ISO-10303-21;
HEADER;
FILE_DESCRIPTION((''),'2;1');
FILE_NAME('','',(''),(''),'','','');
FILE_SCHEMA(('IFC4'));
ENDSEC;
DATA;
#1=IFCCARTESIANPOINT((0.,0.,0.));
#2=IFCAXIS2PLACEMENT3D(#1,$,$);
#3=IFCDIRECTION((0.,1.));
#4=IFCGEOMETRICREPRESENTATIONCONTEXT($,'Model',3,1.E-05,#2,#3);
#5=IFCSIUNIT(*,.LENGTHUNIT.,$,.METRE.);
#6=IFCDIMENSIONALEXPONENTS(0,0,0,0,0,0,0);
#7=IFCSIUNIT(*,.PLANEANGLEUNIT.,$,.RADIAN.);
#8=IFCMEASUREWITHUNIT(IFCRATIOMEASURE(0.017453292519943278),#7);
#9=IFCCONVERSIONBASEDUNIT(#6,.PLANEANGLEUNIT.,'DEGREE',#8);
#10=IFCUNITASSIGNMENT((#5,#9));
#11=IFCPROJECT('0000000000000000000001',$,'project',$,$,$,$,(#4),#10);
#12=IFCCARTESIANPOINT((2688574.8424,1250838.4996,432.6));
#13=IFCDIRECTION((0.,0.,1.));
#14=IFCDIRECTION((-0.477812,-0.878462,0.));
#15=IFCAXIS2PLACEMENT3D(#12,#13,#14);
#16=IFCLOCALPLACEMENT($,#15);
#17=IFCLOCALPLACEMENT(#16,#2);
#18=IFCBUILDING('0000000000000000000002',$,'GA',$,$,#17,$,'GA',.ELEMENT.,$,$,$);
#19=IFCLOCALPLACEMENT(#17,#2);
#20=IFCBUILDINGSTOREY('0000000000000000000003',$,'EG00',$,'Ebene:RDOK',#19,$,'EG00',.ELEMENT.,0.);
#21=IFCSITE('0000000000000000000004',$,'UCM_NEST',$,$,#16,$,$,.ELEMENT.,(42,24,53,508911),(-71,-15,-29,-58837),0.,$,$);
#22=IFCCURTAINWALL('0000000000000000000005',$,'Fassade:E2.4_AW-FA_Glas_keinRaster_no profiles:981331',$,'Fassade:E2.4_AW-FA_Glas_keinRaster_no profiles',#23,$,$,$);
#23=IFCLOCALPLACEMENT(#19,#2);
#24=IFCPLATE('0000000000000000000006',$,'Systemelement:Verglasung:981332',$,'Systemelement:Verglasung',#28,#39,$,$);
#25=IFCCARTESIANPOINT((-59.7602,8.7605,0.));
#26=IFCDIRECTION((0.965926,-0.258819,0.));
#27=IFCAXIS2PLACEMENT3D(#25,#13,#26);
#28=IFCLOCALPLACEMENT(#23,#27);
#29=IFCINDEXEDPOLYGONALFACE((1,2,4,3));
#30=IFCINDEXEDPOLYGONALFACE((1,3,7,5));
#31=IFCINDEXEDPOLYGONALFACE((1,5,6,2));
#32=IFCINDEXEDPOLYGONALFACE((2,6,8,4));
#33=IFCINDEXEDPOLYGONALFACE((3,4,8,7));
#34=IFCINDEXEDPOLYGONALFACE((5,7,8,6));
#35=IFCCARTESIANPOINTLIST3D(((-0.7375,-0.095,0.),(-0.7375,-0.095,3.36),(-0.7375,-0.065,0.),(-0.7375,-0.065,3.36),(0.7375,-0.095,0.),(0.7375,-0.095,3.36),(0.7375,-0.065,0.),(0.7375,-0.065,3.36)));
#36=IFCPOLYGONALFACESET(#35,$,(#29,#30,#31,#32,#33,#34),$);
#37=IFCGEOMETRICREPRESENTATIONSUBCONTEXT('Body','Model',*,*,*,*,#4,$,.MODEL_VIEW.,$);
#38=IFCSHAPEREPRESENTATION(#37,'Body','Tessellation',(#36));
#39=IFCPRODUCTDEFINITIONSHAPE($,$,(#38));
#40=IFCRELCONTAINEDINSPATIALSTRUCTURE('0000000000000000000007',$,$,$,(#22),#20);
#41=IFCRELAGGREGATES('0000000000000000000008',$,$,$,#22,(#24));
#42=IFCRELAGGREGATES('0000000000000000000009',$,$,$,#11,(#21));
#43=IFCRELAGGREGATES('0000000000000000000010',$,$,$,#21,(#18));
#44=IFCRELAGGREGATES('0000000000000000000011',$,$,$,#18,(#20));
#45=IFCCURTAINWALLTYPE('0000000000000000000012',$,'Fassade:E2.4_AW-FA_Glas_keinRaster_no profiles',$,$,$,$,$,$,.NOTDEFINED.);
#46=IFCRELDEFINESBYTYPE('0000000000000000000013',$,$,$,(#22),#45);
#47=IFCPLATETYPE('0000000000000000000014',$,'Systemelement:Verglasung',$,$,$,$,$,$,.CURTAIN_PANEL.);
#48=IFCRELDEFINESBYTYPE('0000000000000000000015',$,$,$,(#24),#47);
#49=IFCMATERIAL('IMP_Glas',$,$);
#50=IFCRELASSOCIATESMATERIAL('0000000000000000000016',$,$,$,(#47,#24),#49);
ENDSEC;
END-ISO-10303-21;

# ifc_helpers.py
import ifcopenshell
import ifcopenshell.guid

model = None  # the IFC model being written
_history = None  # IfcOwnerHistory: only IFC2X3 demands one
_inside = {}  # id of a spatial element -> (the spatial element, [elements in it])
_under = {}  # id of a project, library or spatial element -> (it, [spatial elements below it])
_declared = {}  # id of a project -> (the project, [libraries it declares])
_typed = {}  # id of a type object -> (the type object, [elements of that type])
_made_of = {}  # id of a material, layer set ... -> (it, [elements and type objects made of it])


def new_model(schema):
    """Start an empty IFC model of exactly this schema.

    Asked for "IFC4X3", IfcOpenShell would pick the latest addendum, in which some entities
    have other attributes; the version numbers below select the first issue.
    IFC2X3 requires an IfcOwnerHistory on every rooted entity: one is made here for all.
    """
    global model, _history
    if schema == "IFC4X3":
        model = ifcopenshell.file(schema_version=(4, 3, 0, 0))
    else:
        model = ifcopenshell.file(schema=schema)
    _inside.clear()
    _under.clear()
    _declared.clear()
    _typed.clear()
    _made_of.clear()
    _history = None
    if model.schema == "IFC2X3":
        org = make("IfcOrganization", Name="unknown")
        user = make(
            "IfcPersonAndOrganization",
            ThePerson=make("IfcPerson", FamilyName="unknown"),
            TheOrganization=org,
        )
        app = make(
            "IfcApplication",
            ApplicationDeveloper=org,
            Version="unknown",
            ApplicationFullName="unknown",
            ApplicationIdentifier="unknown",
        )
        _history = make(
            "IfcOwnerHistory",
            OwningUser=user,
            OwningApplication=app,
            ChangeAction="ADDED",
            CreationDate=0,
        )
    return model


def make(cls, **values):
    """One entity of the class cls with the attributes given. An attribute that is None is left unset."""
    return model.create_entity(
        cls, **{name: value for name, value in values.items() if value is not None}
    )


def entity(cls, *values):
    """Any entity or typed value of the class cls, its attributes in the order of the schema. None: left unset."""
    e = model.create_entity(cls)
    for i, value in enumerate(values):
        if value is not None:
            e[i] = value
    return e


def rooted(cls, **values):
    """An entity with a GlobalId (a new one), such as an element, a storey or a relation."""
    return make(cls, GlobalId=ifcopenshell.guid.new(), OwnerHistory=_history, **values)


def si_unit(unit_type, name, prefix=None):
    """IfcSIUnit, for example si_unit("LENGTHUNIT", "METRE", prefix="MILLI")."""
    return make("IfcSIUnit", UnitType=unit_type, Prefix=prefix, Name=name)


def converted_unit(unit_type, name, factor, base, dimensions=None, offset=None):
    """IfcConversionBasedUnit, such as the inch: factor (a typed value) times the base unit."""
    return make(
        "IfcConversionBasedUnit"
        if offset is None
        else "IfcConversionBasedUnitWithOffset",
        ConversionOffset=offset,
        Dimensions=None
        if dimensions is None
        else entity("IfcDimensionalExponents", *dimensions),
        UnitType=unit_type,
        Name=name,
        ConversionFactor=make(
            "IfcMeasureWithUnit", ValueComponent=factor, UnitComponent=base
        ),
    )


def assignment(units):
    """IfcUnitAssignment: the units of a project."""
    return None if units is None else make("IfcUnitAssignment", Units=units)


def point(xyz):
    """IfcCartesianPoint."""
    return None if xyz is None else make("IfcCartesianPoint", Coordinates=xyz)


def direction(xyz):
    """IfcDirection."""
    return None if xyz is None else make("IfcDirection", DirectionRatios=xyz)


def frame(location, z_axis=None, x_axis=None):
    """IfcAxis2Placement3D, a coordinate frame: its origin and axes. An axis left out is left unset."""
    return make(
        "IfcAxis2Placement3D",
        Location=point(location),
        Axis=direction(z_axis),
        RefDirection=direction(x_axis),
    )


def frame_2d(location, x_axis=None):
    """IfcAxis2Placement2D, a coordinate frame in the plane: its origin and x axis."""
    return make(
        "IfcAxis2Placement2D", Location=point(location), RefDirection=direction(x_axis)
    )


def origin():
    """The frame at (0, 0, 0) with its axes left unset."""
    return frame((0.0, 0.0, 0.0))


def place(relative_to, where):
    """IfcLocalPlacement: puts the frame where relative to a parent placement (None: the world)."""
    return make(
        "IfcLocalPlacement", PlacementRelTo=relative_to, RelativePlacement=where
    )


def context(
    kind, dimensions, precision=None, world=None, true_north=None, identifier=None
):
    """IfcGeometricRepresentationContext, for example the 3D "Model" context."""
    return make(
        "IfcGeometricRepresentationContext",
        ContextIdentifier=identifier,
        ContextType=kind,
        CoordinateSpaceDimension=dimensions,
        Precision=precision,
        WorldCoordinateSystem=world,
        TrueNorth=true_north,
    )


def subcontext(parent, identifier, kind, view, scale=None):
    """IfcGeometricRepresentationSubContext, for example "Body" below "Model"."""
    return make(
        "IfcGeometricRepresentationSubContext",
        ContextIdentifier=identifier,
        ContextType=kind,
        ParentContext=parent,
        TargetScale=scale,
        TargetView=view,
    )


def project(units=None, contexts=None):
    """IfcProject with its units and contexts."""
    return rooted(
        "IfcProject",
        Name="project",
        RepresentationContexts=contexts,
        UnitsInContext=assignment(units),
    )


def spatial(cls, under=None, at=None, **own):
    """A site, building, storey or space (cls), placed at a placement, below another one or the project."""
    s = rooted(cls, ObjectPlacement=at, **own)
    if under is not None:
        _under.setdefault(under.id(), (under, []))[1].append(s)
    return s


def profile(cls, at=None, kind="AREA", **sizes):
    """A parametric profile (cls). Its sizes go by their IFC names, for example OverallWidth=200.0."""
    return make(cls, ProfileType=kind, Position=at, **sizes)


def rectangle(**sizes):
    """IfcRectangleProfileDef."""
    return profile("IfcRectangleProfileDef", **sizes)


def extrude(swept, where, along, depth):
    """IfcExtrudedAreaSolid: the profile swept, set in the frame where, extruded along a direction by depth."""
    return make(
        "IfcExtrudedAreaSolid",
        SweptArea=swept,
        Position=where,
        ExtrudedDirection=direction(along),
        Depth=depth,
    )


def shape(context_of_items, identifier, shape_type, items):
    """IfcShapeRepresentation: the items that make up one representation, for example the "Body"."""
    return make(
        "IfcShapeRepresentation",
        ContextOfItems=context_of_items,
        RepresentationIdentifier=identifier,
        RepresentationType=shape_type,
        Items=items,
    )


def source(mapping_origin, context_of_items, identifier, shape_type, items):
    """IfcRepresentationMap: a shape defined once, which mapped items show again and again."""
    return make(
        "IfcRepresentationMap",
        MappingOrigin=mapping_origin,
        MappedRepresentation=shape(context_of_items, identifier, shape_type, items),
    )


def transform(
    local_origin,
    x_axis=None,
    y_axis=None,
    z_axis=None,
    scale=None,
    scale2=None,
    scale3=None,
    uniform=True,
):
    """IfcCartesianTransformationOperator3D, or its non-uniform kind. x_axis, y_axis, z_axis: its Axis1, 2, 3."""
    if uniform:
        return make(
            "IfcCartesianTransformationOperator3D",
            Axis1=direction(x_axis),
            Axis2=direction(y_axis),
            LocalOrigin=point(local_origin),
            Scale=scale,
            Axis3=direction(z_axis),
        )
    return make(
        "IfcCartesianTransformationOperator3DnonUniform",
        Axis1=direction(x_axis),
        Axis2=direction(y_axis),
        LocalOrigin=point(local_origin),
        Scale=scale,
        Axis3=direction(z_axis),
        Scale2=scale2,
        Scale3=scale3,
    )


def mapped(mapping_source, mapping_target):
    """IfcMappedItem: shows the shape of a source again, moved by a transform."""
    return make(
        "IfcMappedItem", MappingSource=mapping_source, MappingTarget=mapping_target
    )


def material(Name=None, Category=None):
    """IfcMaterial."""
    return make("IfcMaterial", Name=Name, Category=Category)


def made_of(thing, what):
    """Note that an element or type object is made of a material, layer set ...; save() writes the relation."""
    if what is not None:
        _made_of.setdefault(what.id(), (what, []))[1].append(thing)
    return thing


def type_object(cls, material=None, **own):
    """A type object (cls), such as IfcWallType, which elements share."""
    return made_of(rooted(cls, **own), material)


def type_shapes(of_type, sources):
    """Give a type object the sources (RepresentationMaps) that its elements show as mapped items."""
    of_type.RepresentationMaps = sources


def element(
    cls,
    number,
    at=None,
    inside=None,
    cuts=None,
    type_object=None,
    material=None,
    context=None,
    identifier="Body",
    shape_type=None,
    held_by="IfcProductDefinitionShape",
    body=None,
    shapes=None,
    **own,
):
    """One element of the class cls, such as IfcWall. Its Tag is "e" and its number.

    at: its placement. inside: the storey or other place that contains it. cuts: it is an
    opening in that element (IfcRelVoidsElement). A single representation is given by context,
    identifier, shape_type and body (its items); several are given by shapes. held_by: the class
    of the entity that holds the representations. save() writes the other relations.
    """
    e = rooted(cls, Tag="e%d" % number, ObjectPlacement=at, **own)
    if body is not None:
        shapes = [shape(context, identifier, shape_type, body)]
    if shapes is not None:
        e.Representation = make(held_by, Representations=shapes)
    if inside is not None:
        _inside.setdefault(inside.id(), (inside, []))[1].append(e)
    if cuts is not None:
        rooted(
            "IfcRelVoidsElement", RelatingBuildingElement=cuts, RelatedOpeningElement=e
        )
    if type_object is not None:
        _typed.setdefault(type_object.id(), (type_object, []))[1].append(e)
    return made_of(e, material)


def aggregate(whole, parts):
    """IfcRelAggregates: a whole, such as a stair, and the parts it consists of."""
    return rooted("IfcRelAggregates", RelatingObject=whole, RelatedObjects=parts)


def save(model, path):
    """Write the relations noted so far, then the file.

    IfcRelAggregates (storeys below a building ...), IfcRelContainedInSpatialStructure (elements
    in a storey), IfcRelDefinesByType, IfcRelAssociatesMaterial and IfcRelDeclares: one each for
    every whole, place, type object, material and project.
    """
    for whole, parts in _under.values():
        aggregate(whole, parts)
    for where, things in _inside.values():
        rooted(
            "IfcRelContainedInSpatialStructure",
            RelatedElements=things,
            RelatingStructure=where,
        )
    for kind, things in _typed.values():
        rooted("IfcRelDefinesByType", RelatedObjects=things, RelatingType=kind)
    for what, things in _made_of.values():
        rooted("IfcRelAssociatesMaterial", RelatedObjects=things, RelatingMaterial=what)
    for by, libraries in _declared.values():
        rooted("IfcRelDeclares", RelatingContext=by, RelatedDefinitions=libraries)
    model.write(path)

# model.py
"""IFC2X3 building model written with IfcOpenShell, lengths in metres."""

from ifc_helpers import new_model, entity, si_unit, converted_unit, direction, frame, frame_2d, origin, place, context, subcontext, project, spatial, rectangle, extrude, source, transform, mapped, material, type_object, type_shapes, element, aggregate, save


model = new_model("IFC2X3")

# Units and contexts
model_context = context("Model", 3, precision=1e-05, world=origin(), true_north=direction((0.0, 1.0)))
body_context = subcontext(model_context, "Body", "Model", "MODEL_VIEW")
ifc_project = project(units=[si_unit("LENGTHUNIT", "METRE"), converted_unit("PLANEANGLEUNIT", "DEGREE", entity("IfcRatioMeasure", 0.017453292519943278), si_unit("PLANEANGLEUNIT", "RADIAN"), dimensions=[0, 0, 0, 0, 0, 0, 0])], contexts=[model_context])

# Site, building, storey
site_placement = place(None, frame((2688574.8424, 1250838.4996, 432.6), z_axis=(0.0, 0.0, 1.0), x_axis=(-0.477812, -0.878462, 0.0)))
site = spatial("IfcSite", under=ifc_project, at=site_placement, Name="UCM_NEST", CompositionType="ELEMENT", RefLatitude=(42, 24, 53, 508911), RefLongitude=(-71, -15, -29, -58837), RefElevation=0.0)
building_placement = place(site_placement, origin())
building = spatial("IfcBuilding", under=site, at=building_placement, Name="GA", LongName="GA", CompositionType="ELEMENT")
storey_placement = place(building_placement, origin())
storey = spatial("IfcBuildingStorey", under=building, at=storey_placement, Name="EG00", ObjectType="Ebene:RDOK", LongName="EG00", CompositionType="ELEMENT", Elevation=0.0)

# Curtain wall, plate
curtain_wall_type = type_object("IfcCurtainWallType", Name="Fassade:E2.4_AW-FA_Glas_keinRaster_no profiles", PredefinedType="NOTDEFINED")
ifc_material_1 = material(Name="IMP_Glas")
plate_type_1 = type_object("IfcPlateType", Name="Systemelement:Verglasung", PredefinedType="CURTAIN_PANEL", material=ifc_material_1)
shared_shape_1 = source(origin(), body_context, "Body", "SweptSolid", [
    extrude(rectangle(XDim=0.03, YDim=1.475, at=frame_2d((0.0, 0.0), x_axis=(1.0, 0.0))), frame((0.0, -0.08, 0.0), z_axis=(0.0, 0.0, 1.0), x_axis=(0.0, 1.0, 0.0)), (0.0, 0.0, 1.0), 3.36),
])
type_shapes(plate_type_1, [shared_shape_1])
curtain_wall_1_placement = place(storey_placement, origin())
curtain_wall_1 = element("IfcCurtainWall", 1, at=curtain_wall_1_placement, inside=storey, type_object=curtain_wall_type, Name="Fassade:E2.4_AW-FA_Glas_keinRaster_no profiles:981331", ObjectType="Fassade:E2.4_AW-FA_Glas_keinRaster_no profiles")
plate_1_placement = place(curtain_wall_1_placement, frame((-59.7602, 8.7605, 0.0), z_axis=(0.0, 0.0, 1.0), x_axis=(0.965926, -0.258819, 0.0)))
plate_1 = element("IfcPlate", 2, at=plate_1_placement, type_object=plate_type_1, material=ifc_material_1, Name="Systemelement:Verglasung:981332", ObjectType="Systemelement:Verglasung", context=body_context, shape_type="MappedRepresentation", body=[
    mapped(shared_shape_1, transform((0.0, 0.0, 0.0), scale=1.0)),
])
aggregate(curtain_wall_1, [plate_1])

save(model, "model.ifc")
